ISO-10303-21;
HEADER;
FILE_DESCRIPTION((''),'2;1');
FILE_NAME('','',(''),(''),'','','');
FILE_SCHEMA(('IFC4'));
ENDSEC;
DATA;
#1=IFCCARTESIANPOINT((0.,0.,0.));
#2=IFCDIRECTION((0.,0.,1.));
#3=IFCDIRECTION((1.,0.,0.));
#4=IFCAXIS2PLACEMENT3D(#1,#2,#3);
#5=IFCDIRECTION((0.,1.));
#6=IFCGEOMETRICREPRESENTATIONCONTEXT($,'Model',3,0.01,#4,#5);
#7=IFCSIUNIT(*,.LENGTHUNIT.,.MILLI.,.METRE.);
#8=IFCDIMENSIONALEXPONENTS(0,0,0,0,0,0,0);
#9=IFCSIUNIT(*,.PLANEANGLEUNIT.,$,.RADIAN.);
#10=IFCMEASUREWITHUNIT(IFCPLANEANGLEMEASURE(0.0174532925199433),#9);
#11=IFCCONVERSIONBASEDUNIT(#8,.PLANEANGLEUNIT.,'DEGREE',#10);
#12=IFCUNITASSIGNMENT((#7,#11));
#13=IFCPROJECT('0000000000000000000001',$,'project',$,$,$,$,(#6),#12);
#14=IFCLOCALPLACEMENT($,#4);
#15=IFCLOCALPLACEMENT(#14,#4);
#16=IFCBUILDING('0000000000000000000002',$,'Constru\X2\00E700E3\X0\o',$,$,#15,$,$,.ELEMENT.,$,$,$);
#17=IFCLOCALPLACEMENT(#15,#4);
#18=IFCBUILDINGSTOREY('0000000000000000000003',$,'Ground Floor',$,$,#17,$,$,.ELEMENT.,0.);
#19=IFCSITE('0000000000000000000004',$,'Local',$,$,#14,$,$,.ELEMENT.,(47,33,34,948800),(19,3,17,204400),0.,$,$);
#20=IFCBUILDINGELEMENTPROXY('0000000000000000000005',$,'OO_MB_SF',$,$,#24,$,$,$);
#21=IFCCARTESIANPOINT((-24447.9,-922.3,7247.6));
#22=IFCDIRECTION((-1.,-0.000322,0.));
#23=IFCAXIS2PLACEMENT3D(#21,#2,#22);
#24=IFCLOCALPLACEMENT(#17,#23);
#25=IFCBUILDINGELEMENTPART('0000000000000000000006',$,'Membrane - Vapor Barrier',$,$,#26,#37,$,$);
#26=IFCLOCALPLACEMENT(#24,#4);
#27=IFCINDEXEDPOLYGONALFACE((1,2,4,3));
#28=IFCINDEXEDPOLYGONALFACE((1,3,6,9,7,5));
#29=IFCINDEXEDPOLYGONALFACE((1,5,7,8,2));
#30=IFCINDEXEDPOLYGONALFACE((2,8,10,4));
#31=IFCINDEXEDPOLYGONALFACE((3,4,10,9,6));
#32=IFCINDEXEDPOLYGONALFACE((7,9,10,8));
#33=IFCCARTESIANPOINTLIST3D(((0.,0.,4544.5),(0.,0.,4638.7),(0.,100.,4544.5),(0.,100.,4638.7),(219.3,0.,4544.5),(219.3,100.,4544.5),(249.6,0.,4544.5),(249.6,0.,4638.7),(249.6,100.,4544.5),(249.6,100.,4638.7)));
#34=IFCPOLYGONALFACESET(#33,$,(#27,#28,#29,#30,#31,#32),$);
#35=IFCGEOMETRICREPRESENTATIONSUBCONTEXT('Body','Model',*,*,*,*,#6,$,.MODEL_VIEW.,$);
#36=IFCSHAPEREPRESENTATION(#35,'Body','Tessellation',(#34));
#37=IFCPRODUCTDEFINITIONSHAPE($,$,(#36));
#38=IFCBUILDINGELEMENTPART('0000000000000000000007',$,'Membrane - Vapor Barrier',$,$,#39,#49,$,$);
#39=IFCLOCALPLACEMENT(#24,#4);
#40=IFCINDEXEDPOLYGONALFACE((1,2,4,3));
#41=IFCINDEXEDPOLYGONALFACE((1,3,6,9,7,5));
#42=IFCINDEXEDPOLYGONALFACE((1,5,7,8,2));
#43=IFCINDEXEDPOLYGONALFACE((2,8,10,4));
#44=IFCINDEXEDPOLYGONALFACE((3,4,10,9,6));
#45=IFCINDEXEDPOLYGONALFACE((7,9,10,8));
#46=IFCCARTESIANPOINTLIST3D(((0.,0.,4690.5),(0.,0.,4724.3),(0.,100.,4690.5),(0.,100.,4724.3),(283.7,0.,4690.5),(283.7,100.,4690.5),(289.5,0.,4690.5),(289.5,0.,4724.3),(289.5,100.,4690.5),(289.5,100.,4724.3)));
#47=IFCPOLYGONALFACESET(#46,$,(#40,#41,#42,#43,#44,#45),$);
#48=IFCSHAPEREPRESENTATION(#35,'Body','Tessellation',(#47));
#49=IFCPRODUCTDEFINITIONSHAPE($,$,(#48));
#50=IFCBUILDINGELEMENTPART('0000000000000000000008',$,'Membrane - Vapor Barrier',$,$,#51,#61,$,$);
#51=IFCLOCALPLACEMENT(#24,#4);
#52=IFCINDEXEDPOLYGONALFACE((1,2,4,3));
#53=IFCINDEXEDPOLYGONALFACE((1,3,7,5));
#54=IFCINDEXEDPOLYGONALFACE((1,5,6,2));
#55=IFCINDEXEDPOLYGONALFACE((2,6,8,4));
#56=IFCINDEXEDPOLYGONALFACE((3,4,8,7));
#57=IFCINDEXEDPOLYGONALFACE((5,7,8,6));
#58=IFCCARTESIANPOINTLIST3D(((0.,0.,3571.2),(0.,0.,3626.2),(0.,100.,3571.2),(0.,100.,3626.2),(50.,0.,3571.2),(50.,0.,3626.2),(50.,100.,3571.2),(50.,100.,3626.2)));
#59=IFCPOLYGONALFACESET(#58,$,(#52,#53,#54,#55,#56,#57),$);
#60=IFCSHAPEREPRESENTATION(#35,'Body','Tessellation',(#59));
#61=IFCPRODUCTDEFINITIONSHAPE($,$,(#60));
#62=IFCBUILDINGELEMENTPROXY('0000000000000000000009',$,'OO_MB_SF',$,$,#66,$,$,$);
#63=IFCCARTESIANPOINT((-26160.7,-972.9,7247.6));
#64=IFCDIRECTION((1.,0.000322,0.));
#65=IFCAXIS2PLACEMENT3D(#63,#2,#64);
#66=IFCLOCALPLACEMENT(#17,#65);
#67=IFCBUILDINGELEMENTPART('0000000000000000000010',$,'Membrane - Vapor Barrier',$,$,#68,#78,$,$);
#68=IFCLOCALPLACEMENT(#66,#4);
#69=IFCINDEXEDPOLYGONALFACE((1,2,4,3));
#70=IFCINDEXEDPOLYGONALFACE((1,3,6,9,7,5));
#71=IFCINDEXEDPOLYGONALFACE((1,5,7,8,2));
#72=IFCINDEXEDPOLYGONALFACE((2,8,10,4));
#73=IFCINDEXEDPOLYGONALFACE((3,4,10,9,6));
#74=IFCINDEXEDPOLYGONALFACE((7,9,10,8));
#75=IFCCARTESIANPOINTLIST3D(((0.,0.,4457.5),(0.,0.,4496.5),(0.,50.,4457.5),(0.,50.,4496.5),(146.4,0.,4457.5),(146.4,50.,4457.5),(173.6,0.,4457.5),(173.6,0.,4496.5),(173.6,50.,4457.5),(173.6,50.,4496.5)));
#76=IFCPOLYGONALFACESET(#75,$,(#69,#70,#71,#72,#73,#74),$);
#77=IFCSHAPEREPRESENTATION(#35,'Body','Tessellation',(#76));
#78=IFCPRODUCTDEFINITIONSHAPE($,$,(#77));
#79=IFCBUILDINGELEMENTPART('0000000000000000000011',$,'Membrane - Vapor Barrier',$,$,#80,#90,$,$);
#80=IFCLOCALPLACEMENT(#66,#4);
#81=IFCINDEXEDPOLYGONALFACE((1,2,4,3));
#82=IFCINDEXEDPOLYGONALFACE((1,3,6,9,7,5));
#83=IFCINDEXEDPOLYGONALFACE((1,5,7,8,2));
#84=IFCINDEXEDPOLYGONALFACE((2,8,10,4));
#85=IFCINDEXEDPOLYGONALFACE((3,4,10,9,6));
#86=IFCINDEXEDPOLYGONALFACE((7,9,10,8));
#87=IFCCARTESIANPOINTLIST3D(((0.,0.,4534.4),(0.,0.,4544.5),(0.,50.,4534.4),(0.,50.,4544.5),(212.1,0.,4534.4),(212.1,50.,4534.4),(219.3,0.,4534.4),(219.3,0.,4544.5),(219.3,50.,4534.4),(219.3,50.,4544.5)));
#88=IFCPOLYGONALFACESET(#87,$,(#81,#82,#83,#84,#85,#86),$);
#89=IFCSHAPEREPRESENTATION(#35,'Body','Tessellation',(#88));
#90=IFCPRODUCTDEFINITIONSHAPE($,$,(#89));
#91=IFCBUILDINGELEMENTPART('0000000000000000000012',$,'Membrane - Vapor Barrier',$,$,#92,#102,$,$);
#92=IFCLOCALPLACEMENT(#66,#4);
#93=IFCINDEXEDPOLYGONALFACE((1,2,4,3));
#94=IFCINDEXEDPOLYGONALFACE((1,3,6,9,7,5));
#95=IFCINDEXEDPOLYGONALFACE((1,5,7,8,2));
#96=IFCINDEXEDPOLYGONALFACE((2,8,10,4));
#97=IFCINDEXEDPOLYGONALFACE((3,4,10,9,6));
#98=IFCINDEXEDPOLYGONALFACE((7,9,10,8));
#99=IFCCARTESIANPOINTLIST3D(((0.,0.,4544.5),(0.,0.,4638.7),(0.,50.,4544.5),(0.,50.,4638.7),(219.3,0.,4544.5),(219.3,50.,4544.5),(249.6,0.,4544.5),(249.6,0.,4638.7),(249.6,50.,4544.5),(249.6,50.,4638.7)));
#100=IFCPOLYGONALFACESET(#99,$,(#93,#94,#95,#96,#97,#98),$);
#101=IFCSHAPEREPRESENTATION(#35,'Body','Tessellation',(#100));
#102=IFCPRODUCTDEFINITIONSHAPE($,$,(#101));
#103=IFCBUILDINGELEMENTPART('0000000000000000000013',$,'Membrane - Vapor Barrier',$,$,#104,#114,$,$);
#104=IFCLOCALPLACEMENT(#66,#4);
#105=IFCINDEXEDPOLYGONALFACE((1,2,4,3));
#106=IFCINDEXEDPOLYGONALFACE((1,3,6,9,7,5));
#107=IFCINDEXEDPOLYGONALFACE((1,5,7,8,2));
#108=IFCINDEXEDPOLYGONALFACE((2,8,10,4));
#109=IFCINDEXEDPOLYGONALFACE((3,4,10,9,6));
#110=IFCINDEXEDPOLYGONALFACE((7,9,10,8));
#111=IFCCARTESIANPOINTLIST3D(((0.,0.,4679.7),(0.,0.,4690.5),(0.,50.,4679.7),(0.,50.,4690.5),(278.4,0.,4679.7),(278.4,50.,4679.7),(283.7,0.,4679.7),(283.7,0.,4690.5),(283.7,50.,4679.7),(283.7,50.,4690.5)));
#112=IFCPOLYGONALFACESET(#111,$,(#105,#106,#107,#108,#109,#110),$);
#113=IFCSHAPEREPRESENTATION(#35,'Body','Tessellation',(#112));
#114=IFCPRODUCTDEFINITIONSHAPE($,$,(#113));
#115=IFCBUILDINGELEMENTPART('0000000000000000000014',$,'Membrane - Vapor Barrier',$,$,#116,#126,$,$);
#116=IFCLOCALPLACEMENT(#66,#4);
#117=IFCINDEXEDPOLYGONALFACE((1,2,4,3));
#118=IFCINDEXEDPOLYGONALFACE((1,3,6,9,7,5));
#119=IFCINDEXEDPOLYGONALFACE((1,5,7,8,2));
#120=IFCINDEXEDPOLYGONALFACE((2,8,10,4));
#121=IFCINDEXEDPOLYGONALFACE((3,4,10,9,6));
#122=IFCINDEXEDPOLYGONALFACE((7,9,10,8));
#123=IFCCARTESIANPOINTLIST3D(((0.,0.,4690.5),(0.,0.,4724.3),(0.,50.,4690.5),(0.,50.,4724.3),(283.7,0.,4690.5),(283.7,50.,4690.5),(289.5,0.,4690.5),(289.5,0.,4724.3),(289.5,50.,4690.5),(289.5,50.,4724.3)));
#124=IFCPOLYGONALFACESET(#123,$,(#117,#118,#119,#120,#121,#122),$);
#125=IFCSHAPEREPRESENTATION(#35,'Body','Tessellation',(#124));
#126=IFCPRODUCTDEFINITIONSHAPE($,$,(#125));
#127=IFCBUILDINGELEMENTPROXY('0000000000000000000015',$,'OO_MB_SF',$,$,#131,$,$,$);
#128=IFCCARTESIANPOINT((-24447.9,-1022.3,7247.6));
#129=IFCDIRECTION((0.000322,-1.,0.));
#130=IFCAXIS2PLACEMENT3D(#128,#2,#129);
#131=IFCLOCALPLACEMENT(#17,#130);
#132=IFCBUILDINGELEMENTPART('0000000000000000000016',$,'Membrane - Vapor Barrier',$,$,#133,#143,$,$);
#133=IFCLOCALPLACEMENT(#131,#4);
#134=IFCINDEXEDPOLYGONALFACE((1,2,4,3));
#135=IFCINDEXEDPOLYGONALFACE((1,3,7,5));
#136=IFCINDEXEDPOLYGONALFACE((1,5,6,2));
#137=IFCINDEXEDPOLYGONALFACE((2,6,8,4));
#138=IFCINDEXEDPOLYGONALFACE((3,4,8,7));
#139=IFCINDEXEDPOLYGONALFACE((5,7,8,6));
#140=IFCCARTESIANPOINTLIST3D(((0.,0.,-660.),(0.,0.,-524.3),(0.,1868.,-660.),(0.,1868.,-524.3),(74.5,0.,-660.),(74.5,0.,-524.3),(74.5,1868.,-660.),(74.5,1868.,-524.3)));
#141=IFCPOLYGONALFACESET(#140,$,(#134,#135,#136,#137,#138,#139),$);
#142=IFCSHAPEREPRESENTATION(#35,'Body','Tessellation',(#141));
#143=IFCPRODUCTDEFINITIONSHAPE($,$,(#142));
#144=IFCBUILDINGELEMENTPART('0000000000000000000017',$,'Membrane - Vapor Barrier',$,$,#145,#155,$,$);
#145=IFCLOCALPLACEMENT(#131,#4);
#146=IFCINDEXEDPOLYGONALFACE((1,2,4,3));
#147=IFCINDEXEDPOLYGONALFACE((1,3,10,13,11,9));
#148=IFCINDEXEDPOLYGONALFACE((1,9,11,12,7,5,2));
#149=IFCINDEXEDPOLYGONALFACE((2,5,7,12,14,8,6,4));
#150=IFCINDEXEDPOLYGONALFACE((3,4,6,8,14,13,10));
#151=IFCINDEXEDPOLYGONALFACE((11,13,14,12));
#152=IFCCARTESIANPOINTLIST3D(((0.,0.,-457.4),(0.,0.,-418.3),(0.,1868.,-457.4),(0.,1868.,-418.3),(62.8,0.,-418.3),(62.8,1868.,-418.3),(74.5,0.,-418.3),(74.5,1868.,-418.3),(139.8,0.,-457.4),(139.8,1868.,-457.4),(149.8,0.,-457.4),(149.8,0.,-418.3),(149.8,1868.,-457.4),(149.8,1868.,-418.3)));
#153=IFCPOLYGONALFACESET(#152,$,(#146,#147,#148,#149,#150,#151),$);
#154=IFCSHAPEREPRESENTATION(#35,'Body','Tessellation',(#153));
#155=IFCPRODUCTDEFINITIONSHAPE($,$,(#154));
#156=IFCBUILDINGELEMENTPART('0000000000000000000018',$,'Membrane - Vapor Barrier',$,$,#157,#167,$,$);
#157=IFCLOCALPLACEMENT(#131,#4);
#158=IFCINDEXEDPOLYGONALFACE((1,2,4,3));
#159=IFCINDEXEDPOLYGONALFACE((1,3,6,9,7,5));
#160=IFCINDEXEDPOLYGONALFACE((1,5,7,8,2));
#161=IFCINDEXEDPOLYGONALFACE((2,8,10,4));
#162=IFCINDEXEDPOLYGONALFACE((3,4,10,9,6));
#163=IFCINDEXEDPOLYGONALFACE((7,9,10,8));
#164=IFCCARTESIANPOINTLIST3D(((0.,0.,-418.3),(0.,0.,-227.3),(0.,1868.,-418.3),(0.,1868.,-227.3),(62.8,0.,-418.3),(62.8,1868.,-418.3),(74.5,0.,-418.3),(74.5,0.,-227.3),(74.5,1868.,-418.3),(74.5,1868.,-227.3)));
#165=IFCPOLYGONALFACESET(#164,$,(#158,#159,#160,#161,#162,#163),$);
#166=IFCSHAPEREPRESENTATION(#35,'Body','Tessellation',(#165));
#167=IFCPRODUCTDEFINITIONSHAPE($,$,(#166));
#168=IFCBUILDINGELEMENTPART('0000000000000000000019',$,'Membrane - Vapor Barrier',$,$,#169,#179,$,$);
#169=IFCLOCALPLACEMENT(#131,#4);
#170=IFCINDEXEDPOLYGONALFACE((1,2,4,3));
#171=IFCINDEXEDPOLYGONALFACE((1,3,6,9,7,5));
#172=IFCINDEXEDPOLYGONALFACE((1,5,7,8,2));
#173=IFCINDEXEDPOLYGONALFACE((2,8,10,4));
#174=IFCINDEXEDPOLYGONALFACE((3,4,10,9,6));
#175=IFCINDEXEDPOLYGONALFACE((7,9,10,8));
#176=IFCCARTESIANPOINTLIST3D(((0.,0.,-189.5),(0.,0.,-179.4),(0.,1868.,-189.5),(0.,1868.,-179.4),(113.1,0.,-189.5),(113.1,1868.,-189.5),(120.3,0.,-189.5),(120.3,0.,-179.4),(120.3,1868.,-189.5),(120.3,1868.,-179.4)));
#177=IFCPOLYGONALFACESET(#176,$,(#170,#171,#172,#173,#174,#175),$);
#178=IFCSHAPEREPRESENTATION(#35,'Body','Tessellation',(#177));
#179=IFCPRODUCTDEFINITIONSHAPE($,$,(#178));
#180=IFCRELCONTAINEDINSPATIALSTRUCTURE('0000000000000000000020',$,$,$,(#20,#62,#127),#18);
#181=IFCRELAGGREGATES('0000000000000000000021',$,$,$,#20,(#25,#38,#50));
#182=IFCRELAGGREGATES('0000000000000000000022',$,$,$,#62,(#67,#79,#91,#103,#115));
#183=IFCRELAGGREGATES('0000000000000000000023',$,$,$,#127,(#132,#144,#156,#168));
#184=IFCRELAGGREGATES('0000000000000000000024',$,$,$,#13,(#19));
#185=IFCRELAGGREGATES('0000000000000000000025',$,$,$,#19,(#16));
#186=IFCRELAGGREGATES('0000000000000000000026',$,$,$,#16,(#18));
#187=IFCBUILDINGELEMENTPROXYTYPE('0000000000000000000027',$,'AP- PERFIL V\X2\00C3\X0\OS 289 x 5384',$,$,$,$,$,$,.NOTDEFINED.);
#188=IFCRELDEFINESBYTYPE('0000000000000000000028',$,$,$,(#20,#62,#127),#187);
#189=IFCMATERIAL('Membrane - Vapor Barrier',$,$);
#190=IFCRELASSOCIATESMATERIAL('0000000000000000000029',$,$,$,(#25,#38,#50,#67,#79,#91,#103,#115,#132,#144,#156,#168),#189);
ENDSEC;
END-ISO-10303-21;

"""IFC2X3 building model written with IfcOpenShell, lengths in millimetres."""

from ifc_helpers import new_model, entity, si_unit, converted_unit, direction, frame, origin_with_axes, place, context, subcontext, project, spatial, polyline, outline, extrude, material, type_object, element, aggregate, save


model = new_model("IFC2X3")

# Units and contexts
model_context = context("Model", 3, precision=0.01, world=origin_with_axes(), true_north=direction((0.0, 1.0)))
body_context = subcontext(model_context, "Body", "Model", "MODEL_VIEW")
ifc_project = project(units=[si_unit("LENGTHUNIT", "METRE", prefix="MILLI"), converted_unit("PLANEANGLEUNIT", "DEGREE", entity("IfcPlaneAngleMeasure", 0.0174532925199433), si_unit("PLANEANGLEUNIT", "RADIAN"), dimensions=[0, 0, 0, 0, 0, 0, 0])], contexts=[model_context])

# Site, building, storey
site_placement = place(None, origin_with_axes())
site = spatial("IfcSite", under=ifc_project, at=site_placement, Name="Local", CompositionType="ELEMENT", RefLatitude=(47, 33, 34, 948800), RefLongitude=(19, 3, 17, 204400), RefElevation=0.0)
building_placement = place(site_placement, origin_with_axes())
building = spatial("IfcBuilding", under=site, at=building_placement, Name="Construção", CompositionType="ELEMENT")
storey_placement = place(building_placement, origin_with_axes())
storey = spatial("IfcBuildingStorey", under=building, at=storey_placement, Name="Ground Floor", CompositionType="ELEMENT", Elevation=0.0)

# Building element proxies, building element parts
building_element_proxy_type = type_object("IfcBuildingElementProxyType", Name="AP- PERFIL VÃOS 289 x 5384", PredefinedType="NOTDEFINED")
proxy_1_placement = place(storey_placement, frame((-24447.9, -922.3, 7247.6), z_axis=(0.0, 0.0, 1.0), x_axis=(-1.0, -0.000322, 0.0)))
proxy_1 = element("IfcBuildingElementProxy", 1, at=proxy_1_placement, inside=storey, type_object=building_element_proxy_type, Name="OO_MB_SF")
ifc_material = material(Name="Membrane - Vapor Barrier")
building_element_part_1_placement = place(proxy_1_placement, origin_with_axes())
building_element_part_1 = element("IfcBuildingElementPart", 2, at=building_element_part_1_placement, material=ifc_material, Name="Membrane - Vapor Barrier", context=body_context, shape_type="SweptSolid", body=[
    extrude(outline(polyline([(249.6, 4638.7), (0.0, 4638.7), (0.0, 4544.5), (219.3, 4544.5), (249.6, 4544.5), (249.6, 4638.7)])), frame((0.0, 100.0, 0.0), z_axis=(0.0, -1.0, 0.0), x_axis=(1.0, 0.0, 0.0)), (0.0, 0.0, 1.0), 100.0),
])
building_element_part_2_placement = place(proxy_1_placement, origin_with_axes())
building_element_part_2 = element("IfcBuildingElementPart", 3, at=building_element_part_2_placement, material=ifc_material, Name="Membrane - Vapor Barrier", context=body_context, shape_type="SweptSolid", body=[
    extrude(outline(polyline([(0.0, 4690.5), (283.7, 4690.5), (289.5, 4690.5), (289.5, 4724.3), (0.0, 4724.3), (0.0, 4690.5)])), frame((0.0, 100.0, 0.0), z_axis=(0.0, -1.0, 0.0), x_axis=(1.0, 0.0, 0.0)), (0.0, 0.0, 1.0), 100.0),
])
building_element_part_3_placement = place(proxy_1_placement, origin_with_axes())
building_element_part_3 = element("IfcBuildingElementPart", 4, at=building_element_part_3_placement, material=ifc_material, Name="Membrane - Vapor Barrier", context=body_context, shape_type="SweptSolid", body=[
    extrude(outline(polyline([(0.0, 3571.2), (50.0, 3571.2), (50.0, 3626.2), (0.0, 3626.2), (0.0, 3571.2)])), frame((0.0, 100.0, 0.0), z_axis=(0.0, -1.0, 0.0), x_axis=(1.0, 0.0, 0.0)), (0.0, 0.0, 1.0), 100.0),
])
aggregate(proxy_1, [building_element_part_1, building_element_part_2, building_element_part_3])
proxy_2_placement = place(storey_placement, frame((-26160.7, -972.9, 7247.6), z_axis=(0.0, 0.0, 1.0), x_axis=(1.0, 0.000322, 0.0)))
proxy_2 = element("IfcBuildingElementProxy", 5, at=proxy_2_placement, inside=storey, type_object=building_element_proxy_type, Name="OO_MB_SF")
building_element_part_4_placement = place(proxy_2_placement, origin_with_axes())
building_element_part_4 = element("IfcBuildingElementPart", 6, at=building_element_part_4_placement, material=ifc_material, Name="Membrane - Vapor Barrier", context=body_context, shape_type="SweptSolid", body=[
    extrude(outline(polyline([(173.6, 4496.5), (0.0, 4496.5), (0.0, 4457.5), (146.4, 4457.5), (173.6, 4457.5), (173.6, 4496.5)])), frame((0.0, 50.0, 0.0), z_axis=(0.0, -1.0, 0.0), x_axis=(1.0, 0.0, 0.0)), (0.0, 0.0, 1.0), 50.0),
])
building_element_part_5_placement = place(proxy_2_placement, origin_with_axes())
building_element_part_5 = element("IfcBuildingElementPart", 7, at=building_element_part_5_placement, material=ifc_material, Name="Membrane - Vapor Barrier", context=body_context, shape_type="SweptSolid", body=[
    extrude(outline(polyline([(0.0, 4534.4), (212.1, 4534.4), (219.3, 4534.4), (219.3, 4544.5), (0.0, 4544.5), (0.0, 4534.4)])), frame((0.0, 50.0, 0.0), z_axis=(0.0, -1.0, 0.0), x_axis=(1.0, 0.0, 0.0)), (0.0, 0.0, 1.0), 50.0),
])
building_element_part_6_placement = place(proxy_2_placement, origin_with_axes())
building_element_part_6 = element("IfcBuildingElementPart", 8, at=building_element_part_6_placement, material=ifc_material, Name="Membrane - Vapor Barrier", context=body_context, shape_type="SweptSolid", body=[
    extrude(outline(polyline([(249.6, 4638.7), (0.0, 4638.7), (0.0, 4544.5), (219.3, 4544.5), (249.6, 4544.5), (249.6, 4638.7)])), frame((0.0, 50.0, 0.0), z_axis=(0.0, -1.0, 0.0), x_axis=(1.0, 0.0, 0.0)), (0.0, 0.0, 1.0), 50.0),
])
building_element_part_7_placement = place(proxy_2_placement, origin_with_axes())
building_element_part_7 = element("IfcBuildingElementPart", 9, at=building_element_part_7_placement, material=ifc_material, Name="Membrane - Vapor Barrier", context=body_context, shape_type="SweptSolid", body=[
    extrude(outline(polyline([(0.0, 4679.7), (278.4, 4679.7), (283.7, 4679.7), (283.7, 4690.5), (0.0, 4690.5), (0.0, 4679.7)])), frame((0.0, 50.0, 0.0), z_axis=(0.0, -1.0, 0.0), x_axis=(1.0, 0.0, 0.0)), (0.0, 0.0, 1.0), 50.0),
])
building_element_part_8_placement = place(proxy_2_placement, origin_with_axes())
building_element_part_8 = element("IfcBuildingElementPart", 10, at=building_element_part_8_placement, material=ifc_material, Name="Membrane - Vapor Barrier", context=body_context, shape_type="SweptSolid", body=[
    extrude(outline(polyline([(0.0, 4690.5), (283.7, 4690.5), (289.5, 4690.5), (289.5, 4724.3), (0.0, 4724.3), (0.0, 4690.5)])), frame((0.0, 50.0, 0.0), z_axis=(0.0, -1.0, 0.0), x_axis=(1.0, 0.0, 0.0)), (0.0, 0.0, 1.0), 50.0),
])
aggregate(proxy_2, [building_element_part_4, building_element_part_5, building_element_part_6, building_element_part_7, building_element_part_8])
proxy_3_placement = place(storey_placement, frame((-24447.9, -1022.3, 7247.6), z_axis=(0.0, 0.0, 1.0), x_axis=(0.000322, -1.0, 0.0)))
proxy_3 = element("IfcBuildingElementProxy", 11, at=proxy_3_placement, inside=storey, type_object=building_element_proxy_type, Name="OO_MB_SF")
building_element_part_9_placement = place(proxy_3_placement, origin_with_axes())
building_element_part_9 = element("IfcBuildingElementPart", 12, at=building_element_part_9_placement, material=ifc_material, Name="Membrane - Vapor Barrier", context=body_context, shape_type="SweptSolid", body=[
    extrude(outline(polyline([(0.0, -660.0), (74.5, -660.0), (74.5, -524.3), (0.0, -524.3), (0.0, -660.0)])), frame((0.0, 1868.0, 0.0), z_axis=(0.0, -1.0, 0.0), x_axis=(1.0, 0.0, 0.0)), (0.0, 0.0, 1.0), 1868.0),
])
building_element_part_10_placement = place(proxy_3_placement, origin_with_axes())
building_element_part_10 = element("IfcBuildingElementPart", 13, at=building_element_part_10_placement, material=ifc_material, Name="Membrane - Vapor Barrier", context=body_context, shape_type="SweptSolid", body=[
    extrude(outline(polyline([(62.8, -418.3), (0.0, -418.3), (0.0, -457.4), (139.8, -457.4), (149.8, -457.4), (149.8, -418.3), (74.5, -418.3), (62.8, -418.3)])), frame((0.0, 1868.0, 0.0), z_axis=(0.0, -1.0, 0.0), x_axis=(1.0, 0.0, 0.0)), (0.0, 0.0, 1.0), 1868.0),
])
building_element_part_11_placement = place(proxy_3_placement, origin_with_axes())
building_element_part_11 = element("IfcBuildingElementPart", 14, at=building_element_part_11_placement, material=ifc_material, Name="Membrane - Vapor Barrier", context=body_context, shape_type="SweptSolid", body=[
    extrude(outline(polyline([(0.0, -227.3), (0.0, -418.3), (62.8, -418.3), (74.5, -418.3), (74.5, -227.3), (0.0, -227.3)])), frame((0.0, 1868.0, 0.0), z_axis=(0.0, -1.0, 0.0), x_axis=(1.0, 0.0, 0.0)), (0.0, 0.0, 1.0), 1868.0),
])
building_element_part_12_placement = place(proxy_3_placement, origin_with_axes())
building_element_part_12 = element("IfcBuildingElementPart", 15, at=building_element_part_12_placement, material=ifc_material, Name="Membrane - Vapor Barrier", context=body_context, shape_type="SweptSolid", body=[
    extrude(outline(polyline([(120.3, -179.4), (0.0, -179.4), (0.0, -189.5), (113.1, -189.5), (120.3, -189.5), (120.3, -179.4)])), frame((0.0, 1868.0, 0.0), z_axis=(0.0, -1.0, 0.0), x_axis=(1.0, 0.0, 0.0)), (0.0, 0.0, 1.0), 1868.0),
])
aggregate(proxy_3, [building_element_part_9, building_element_part_10, building_element_part_11, building_element_part_12])

save(model, "model.ifc")
